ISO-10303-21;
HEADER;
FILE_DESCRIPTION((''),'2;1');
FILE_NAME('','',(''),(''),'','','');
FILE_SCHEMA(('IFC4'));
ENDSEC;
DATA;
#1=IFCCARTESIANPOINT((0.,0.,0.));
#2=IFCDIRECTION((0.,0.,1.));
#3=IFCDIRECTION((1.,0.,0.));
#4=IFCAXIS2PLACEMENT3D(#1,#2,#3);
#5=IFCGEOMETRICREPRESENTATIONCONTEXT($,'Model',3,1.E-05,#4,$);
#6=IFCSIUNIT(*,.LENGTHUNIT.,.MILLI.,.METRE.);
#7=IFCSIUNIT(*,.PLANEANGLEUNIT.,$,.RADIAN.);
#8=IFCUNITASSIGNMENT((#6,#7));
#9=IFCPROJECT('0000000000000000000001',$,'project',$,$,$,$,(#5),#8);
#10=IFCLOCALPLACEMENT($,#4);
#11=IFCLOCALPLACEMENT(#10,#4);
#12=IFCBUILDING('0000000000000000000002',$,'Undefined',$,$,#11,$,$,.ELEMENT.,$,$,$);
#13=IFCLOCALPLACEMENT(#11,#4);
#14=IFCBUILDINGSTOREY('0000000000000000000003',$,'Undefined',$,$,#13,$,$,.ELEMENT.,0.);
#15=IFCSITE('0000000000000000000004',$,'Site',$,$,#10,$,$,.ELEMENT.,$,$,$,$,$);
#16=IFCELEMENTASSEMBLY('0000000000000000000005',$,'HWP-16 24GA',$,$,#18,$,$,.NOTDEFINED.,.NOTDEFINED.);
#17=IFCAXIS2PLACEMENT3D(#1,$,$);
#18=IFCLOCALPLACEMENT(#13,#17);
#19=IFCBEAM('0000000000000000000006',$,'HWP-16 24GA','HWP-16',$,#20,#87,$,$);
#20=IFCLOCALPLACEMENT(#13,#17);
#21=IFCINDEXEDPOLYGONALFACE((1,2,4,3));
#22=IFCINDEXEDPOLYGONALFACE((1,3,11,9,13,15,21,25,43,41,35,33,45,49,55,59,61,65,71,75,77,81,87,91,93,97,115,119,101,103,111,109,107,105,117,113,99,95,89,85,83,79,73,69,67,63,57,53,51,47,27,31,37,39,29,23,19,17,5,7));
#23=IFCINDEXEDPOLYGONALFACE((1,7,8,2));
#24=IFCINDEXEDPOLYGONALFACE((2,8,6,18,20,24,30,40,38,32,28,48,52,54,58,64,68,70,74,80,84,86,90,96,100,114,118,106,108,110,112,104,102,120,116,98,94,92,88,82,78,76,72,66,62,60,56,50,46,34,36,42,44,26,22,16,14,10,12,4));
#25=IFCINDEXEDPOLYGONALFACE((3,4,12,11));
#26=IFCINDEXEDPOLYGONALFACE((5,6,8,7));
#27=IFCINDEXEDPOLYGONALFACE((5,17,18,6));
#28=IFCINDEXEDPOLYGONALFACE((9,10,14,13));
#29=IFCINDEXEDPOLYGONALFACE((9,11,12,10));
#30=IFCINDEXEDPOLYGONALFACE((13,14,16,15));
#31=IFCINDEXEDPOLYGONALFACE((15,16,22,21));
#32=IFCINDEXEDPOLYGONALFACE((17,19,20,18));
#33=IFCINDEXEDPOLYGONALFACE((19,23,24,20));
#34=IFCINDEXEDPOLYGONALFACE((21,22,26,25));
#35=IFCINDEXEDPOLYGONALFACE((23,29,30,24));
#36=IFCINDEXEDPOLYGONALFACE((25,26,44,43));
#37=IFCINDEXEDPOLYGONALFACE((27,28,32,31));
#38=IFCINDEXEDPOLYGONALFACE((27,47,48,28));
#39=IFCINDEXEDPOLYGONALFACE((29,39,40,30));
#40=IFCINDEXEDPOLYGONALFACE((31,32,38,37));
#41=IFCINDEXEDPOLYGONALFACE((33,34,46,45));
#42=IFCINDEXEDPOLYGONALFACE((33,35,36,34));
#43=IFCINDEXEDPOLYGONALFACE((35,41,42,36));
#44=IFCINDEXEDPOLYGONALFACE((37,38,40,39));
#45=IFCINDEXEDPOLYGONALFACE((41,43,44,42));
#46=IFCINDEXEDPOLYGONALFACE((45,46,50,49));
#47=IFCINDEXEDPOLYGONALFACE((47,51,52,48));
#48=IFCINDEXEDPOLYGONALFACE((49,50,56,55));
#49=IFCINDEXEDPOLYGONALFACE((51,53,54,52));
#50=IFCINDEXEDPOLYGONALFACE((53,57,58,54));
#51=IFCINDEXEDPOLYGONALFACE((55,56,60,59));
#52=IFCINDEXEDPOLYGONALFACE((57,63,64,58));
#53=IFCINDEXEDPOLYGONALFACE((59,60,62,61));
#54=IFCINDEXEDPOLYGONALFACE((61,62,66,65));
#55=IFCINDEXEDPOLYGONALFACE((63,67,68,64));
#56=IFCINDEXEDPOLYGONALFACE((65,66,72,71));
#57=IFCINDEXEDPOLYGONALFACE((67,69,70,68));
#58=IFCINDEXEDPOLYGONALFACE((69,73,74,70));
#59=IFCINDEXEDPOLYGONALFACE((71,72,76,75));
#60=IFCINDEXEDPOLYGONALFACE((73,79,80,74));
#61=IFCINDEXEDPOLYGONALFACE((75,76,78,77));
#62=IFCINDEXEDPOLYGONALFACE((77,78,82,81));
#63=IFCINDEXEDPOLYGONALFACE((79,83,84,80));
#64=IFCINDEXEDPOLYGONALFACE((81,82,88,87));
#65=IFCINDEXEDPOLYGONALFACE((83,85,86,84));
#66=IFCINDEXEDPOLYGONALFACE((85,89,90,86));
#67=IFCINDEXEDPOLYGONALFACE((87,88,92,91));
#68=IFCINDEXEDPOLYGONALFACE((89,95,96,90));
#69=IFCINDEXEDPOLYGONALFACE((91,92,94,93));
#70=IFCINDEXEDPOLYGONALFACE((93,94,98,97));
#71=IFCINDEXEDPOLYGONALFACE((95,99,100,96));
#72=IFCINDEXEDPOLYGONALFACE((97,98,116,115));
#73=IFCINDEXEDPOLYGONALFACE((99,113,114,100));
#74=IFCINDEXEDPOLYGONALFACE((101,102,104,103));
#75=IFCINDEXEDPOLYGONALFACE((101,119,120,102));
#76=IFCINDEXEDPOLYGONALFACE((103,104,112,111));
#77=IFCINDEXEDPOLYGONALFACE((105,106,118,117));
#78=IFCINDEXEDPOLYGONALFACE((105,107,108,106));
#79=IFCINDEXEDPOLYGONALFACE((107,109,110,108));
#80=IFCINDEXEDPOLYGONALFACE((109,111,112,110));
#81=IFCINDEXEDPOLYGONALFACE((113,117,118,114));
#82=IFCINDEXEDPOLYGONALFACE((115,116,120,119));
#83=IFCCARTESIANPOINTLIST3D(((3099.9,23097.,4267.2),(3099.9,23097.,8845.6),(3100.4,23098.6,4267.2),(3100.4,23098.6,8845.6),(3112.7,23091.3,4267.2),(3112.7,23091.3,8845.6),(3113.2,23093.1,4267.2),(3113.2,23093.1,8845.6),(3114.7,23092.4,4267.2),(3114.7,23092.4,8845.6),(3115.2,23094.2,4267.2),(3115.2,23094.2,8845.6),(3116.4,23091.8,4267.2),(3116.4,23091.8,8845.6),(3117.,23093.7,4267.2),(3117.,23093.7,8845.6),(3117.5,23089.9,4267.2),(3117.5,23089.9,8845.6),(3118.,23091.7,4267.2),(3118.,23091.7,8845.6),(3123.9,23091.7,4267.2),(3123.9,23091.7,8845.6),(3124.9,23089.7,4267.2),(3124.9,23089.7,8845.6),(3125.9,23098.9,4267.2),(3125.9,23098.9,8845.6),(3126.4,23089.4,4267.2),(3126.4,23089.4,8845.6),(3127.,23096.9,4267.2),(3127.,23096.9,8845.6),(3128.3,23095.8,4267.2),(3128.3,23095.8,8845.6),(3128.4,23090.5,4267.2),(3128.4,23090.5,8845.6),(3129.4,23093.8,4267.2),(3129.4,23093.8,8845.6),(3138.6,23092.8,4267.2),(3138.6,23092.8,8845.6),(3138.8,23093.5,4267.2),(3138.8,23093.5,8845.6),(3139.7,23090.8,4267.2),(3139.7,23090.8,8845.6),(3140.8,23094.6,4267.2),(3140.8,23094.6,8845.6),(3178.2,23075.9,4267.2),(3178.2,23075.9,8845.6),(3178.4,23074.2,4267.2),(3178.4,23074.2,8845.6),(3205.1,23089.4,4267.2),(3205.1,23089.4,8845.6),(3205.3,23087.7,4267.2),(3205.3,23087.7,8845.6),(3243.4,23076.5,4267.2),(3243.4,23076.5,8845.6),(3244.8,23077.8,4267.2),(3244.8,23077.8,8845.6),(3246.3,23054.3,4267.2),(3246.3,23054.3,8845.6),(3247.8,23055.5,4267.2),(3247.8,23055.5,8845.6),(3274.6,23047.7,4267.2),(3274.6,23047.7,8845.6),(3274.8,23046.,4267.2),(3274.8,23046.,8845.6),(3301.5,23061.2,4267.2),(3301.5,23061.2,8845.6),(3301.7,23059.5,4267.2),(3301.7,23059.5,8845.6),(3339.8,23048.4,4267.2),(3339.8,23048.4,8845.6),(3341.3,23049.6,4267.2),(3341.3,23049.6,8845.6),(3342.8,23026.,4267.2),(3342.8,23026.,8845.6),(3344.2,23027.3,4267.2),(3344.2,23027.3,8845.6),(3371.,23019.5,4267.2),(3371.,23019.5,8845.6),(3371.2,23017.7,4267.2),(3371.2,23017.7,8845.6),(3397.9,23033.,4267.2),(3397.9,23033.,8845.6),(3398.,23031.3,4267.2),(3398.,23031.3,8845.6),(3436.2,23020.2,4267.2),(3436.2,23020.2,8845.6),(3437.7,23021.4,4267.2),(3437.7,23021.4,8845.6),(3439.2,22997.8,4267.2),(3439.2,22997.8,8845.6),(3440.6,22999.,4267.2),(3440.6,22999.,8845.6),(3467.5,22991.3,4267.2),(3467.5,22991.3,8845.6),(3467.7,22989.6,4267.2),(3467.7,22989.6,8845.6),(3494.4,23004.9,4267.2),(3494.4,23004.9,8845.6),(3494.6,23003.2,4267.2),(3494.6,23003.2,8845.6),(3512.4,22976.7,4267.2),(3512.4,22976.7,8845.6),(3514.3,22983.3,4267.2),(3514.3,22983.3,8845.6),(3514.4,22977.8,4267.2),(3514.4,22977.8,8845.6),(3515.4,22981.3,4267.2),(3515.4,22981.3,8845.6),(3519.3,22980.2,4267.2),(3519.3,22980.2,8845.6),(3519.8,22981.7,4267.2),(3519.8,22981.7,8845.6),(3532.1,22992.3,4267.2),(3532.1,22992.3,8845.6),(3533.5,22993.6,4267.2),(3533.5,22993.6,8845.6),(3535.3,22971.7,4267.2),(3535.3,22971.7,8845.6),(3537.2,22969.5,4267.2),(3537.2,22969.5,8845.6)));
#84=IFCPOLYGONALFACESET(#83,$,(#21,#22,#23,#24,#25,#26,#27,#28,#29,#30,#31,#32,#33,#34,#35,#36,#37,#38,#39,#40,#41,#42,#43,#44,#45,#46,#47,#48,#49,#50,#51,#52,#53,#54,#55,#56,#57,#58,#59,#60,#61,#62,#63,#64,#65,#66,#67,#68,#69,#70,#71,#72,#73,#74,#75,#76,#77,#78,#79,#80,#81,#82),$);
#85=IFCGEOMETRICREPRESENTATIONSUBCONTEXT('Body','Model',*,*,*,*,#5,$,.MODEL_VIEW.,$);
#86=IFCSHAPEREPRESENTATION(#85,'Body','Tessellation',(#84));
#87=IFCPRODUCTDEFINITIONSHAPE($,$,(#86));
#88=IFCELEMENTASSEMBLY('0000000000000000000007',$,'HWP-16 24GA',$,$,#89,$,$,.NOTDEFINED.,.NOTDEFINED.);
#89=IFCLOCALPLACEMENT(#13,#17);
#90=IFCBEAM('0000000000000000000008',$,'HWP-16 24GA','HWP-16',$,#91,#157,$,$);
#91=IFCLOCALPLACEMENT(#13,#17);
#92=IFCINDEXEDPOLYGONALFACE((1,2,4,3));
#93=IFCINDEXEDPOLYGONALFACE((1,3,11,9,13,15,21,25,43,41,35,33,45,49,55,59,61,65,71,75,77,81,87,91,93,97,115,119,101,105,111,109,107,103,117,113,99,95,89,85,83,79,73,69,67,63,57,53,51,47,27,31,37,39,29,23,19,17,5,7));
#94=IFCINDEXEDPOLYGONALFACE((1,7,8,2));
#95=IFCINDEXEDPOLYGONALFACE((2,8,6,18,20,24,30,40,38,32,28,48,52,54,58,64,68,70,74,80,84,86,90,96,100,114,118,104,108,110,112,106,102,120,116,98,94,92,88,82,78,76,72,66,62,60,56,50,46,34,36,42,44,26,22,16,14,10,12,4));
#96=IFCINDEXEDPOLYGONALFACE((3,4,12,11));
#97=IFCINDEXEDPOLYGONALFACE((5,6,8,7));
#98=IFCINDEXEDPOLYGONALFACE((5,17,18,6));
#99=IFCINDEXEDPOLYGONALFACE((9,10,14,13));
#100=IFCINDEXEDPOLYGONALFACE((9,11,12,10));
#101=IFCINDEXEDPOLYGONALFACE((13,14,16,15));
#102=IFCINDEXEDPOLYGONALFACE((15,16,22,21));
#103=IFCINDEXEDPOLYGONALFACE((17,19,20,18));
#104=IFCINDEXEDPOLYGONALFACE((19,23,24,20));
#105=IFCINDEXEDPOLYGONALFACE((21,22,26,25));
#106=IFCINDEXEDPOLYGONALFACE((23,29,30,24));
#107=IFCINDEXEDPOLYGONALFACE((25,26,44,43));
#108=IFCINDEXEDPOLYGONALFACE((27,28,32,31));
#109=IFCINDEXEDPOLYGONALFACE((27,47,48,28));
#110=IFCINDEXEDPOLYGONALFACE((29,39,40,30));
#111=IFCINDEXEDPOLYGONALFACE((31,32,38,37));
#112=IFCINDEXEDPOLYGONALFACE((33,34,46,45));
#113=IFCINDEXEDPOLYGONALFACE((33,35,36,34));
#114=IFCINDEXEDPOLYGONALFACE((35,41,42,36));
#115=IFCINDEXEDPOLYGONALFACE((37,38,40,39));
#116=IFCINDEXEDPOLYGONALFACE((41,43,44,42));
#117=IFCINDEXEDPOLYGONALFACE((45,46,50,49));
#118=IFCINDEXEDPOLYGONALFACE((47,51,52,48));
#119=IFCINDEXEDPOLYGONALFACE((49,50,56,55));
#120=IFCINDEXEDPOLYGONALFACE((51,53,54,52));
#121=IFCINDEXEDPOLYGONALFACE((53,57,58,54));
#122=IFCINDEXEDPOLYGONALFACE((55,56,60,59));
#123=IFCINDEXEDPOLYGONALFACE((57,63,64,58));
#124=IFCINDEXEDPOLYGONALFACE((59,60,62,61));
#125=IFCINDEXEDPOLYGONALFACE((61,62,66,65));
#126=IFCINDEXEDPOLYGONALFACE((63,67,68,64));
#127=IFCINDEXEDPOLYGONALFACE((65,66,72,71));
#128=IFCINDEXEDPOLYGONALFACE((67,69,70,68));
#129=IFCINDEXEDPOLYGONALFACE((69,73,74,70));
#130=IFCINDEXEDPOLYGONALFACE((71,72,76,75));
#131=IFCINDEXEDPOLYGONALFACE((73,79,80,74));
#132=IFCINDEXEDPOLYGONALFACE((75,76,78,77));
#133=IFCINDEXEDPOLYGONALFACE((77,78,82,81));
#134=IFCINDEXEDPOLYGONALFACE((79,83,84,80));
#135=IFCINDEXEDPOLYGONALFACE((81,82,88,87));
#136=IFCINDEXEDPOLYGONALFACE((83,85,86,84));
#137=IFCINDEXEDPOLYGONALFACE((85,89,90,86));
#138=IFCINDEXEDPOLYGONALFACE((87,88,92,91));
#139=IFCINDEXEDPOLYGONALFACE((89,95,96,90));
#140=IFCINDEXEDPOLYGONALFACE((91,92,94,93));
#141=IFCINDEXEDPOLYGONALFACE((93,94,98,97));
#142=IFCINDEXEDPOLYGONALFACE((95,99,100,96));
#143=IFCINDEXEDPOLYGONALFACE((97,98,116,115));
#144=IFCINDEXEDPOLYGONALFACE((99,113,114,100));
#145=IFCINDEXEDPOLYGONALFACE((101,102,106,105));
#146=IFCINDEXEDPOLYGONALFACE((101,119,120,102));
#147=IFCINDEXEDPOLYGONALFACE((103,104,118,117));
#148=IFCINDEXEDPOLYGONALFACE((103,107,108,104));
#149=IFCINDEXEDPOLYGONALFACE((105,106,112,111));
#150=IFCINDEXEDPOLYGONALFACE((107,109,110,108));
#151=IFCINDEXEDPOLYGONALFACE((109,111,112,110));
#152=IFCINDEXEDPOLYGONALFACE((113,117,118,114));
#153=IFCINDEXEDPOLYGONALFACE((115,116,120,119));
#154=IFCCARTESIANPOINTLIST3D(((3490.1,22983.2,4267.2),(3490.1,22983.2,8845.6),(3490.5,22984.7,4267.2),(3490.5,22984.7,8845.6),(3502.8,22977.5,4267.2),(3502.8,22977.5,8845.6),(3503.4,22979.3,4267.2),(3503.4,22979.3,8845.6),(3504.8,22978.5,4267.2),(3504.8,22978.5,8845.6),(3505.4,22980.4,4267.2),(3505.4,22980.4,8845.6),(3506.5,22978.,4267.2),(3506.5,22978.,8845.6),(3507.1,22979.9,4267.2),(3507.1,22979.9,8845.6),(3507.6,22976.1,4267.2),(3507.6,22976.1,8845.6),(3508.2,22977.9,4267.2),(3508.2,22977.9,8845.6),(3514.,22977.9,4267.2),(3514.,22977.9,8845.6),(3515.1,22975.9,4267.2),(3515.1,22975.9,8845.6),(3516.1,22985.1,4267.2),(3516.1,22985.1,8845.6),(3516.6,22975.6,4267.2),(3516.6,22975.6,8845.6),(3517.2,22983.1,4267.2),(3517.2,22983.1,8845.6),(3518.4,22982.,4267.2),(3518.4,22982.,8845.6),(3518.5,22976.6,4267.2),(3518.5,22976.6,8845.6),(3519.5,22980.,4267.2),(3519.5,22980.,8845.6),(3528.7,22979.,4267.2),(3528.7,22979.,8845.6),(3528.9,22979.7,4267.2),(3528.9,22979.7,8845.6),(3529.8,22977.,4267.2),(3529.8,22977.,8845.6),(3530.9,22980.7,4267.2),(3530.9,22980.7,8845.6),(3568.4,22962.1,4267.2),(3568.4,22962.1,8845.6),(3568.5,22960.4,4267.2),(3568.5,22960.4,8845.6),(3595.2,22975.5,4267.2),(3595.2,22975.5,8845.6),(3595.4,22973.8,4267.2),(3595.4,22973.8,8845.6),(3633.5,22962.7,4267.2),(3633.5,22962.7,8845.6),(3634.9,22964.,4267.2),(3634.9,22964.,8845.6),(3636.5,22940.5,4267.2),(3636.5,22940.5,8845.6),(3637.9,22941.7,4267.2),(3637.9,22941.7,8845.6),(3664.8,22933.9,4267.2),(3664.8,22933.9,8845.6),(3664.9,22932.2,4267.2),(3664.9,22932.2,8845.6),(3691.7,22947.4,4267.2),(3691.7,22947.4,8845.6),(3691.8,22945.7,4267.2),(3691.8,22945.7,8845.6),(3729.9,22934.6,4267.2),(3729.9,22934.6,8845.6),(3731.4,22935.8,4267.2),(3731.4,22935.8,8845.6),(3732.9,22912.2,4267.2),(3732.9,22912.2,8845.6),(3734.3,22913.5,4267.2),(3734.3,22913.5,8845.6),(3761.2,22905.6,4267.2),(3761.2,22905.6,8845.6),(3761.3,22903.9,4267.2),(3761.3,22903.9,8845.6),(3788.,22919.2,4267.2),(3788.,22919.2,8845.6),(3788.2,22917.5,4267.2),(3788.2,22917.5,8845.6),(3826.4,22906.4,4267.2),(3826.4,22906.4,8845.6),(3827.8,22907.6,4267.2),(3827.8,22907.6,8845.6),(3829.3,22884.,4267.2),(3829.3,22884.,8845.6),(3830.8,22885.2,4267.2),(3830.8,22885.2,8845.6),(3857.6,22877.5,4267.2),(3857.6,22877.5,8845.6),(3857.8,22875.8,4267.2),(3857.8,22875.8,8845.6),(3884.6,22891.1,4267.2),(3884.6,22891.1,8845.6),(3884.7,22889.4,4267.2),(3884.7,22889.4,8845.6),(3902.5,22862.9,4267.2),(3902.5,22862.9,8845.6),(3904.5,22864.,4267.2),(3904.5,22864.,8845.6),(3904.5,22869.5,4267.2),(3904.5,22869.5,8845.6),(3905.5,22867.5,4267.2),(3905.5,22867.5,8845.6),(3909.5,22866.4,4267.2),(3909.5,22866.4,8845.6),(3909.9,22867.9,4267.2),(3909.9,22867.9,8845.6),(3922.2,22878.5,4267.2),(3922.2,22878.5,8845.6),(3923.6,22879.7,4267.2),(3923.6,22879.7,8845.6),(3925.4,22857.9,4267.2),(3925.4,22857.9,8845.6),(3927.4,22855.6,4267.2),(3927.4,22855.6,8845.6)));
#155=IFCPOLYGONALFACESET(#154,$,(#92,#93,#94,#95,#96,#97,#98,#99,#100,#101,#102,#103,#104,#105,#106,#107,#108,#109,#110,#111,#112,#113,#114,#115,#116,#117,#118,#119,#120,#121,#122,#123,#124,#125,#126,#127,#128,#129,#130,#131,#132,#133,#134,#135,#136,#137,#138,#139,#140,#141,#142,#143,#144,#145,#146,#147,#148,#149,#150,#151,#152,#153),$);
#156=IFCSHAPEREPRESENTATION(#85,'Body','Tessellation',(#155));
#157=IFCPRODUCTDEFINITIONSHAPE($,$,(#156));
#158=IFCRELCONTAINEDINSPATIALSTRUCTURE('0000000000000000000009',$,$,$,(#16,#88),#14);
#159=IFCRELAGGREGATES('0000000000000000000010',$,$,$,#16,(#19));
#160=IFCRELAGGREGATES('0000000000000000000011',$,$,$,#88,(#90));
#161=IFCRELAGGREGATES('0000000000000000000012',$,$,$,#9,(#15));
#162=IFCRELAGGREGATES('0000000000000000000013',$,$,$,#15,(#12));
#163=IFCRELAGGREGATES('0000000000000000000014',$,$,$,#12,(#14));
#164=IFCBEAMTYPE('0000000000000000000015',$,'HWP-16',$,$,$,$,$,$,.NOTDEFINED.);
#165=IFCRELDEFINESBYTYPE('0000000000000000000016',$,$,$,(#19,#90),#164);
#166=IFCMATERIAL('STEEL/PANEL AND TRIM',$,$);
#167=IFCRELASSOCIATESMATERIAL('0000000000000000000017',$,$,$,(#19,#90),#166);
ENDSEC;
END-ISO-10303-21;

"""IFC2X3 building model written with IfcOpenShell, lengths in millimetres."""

from ifc_helpers import new_model, si_unit, frame, origin_with_axes, place, context, subcontext, project, spatial, polyline, outline, extrude, clip, halfspace, material, type_object, element, aggregate, save


model = new_model("IFC2X3")

# Units and contexts
model_context = context("Model", 3, precision=1e-05, world=origin_with_axes())
body_context = subcontext(model_context, "Body", "Model", "MODEL_VIEW")
ifc_project = project(units=[si_unit("LENGTHUNIT", "METRE", prefix="MILLI"), si_unit("PLANEANGLEUNIT", "RADIAN")], contexts=[model_context])

# Site, building, storey
site_placement = place(None, origin_with_axes())
site = spatial("IfcSite", under=ifc_project, at=site_placement, Name="Site", CompositionType="ELEMENT")
building_placement = place(site_placement, origin_with_axes())
building = spatial("IfcBuilding", under=site, at=building_placement, Name="Undefined", CompositionType="ELEMENT")
storey_placement = place(building_placement, origin_with_axes())
storey = spatial("IfcBuildingStorey", under=building, at=storey_placement, Name="Undefined", CompositionType="ELEMENT", Elevation=0.0)

# Element assemblies, beams
ifc_material_1 = material(Name="STEEL/PANEL AND TRIM")
beam_type_1 = type_object("IfcBeamType", Name="HWP-16", PredefinedType="NOTDEFINED")
assembly_1_placement = place(storey_placement, origin_with_axes())
assembly_1 = element("IfcElementAssembly", 1, at=assembly_1_placement, inside=storey, Name="HWP-16 24GA", AssemblyPlace="NOTDEFINED", PredefinedType="NOTDEFINED")
beam_1_placement = place(assembly_1_placement, frame((3533.5, 22993.6, 8845.6), z_axis=(-0.280057, -0.959983, 0.0), x_axis=(0.0, 0.0, -1.0)))
beam_1 = element("IfcBeam", 2, at=beam_1_placement, type_object=beam_type_1, material=ifc_material_1, Name="HWP-16 24GA", Description="HWP-16", context=body_context, shape_type="Clipping", body=[
    clip(extrude(outline(polyline([(40.7, 0.0), (0.0, 0.0), (-10.3, 22.1), (15.5, 22.1), (15.5, 15.2), (9.9, 15.2), (9.9, 16.8), (13.9, 16.8), (13.9, 20.5), (-7.8, 20.5), (1.0, 1.6), (40.1, 1.6), (62.1, 22.2), (91.7, 22.3), (100.8, 1.7), (140.6, 1.7), (162.6, 22.2), (192.2, 22.2), (201.3, 1.6), (241.0, 1.6), (263.1, 22.1), (292.7, 22.1), (301.8, 1.6), (341.5, 1.6), (363.5, 22.0), (417.6, 22.0), (417.6, 15.3), (406.9, 15.3), (406.9, 14.6), (419.2, 14.6), (419.2, 22.1), (426.4, 22.1), (426.4, 24.0), (431.3, 24.0), (431.3, 22.1), (445.2, 22.1), (445.2, 20.5), (429.7, 20.5), (429.7, 22.5), (427.9, 22.5), (427.9, 20.5), (420.7, 20.5), (420.7, 13.0), (405.3, 13.0), (405.3, 16.9), (416.0, 16.9), (416.0, 20.4), (364.1, 20.4), (342.1, 0.0), (300.7, 0.0), (291.6, 20.5), (263.7, 20.5), (241.6, 0.0), (200.3, 0.0), (191.2, 20.6), (163.2, 20.6), (141.3, 0.1), (99.8, 0.1), (90.7, 20.7), (62.7, 20.6), (40.7, 0.0)])), frame((10000.0, 0.0, 0.0), z_axis=(-1.0, 0.0, 0.0), x_axis=(0.0, -1.0, 0.0)), (0.0, 0.0, 1.0), 10000.0), halfspace(frame((4578.4, -500.0, -500.0), z_axis=(1.0, 0.0, 0.0), x_axis=(0.0, 0.0, 1.0)), False)),
])
aggregate(assembly_1, [beam_1])
assembly_2_placement = place(storey_placement, origin_with_axes())
assembly_2 = element("IfcElementAssembly", 3, at=assembly_2_placement, inside=storey, Name="HWP-16 24GA", AssemblyPlace="NOTDEFINED", PredefinedType="NOTDEFINED")
beam_2_placement = place(assembly_2_placement, frame((3923.6, 22879.7, 8845.6), z_axis=(-0.280057, -0.959983, 0.0), x_axis=(0.0, 0.0, -1.0)))
beam_2 = element("IfcBeam", 4, at=beam_2_placement, type_object=beam_type_1, material=ifc_material_1, Name="HWP-16 24GA", Description="HWP-16", context=body_context, shape_type="Clipping", body=[
    clip(extrude(outline(polyline([(40.7, 0.0), (0.0, 0.0), (-10.3, 22.1), (15.5, 22.1), (15.5, 15.2), (9.9, 15.2), (9.9, 16.8), (13.9, 16.8), (13.9, 20.5), (-7.8, 20.5), (1.0, 1.6), (40.1, 1.6), (62.1, 22.2), (91.7, 22.3), (100.8, 1.7), (140.6, 1.7), (162.6, 22.2), (192.2, 22.2), (201.3, 1.6), (241.0, 1.6), (263.1, 22.1), (292.7, 22.1), (301.8, 1.6), (341.5, 1.6), (363.5, 22.0), (417.6, 22.0), (417.6, 15.3), (406.9, 15.3), (406.9, 14.6), (419.2, 14.6), (419.2, 22.1), (426.4, 22.1), (426.4, 24.0), (431.3, 24.0), (431.3, 22.1), (445.2, 22.1), (445.2, 20.5), (429.7, 20.5), (429.7, 22.5), (427.9, 22.5), (427.9, 20.5), (420.7, 20.5), (420.7, 13.0), (405.3, 13.0), (405.3, 16.9), (416.0, 16.9), (416.0, 20.4), (364.1, 20.4), (342.1, 0.0), (300.7, 0.0), (291.6, 20.5), (263.7, 20.5), (241.6, 0.0), (200.3, 0.0), (191.2, 20.6), (163.2, 20.6), (141.3, 0.1), (99.8, 0.1), (90.7, 20.7), (62.7, 20.6), (40.7, 0.0)])), frame((10000.0, 0.0, 0.0), z_axis=(-1.0, 0.0, 0.0), x_axis=(0.0, -1.0, 0.0)), (0.0, 0.0, 1.0), 10000.0), halfspace(frame((4578.4, -500.0, -500.0), z_axis=(1.0, 0.0, 0.0), x_axis=(0.0, 0.0, 1.0)), False)),
])
aggregate(assembly_2, [beam_2])

save(model, "model.ifc")
